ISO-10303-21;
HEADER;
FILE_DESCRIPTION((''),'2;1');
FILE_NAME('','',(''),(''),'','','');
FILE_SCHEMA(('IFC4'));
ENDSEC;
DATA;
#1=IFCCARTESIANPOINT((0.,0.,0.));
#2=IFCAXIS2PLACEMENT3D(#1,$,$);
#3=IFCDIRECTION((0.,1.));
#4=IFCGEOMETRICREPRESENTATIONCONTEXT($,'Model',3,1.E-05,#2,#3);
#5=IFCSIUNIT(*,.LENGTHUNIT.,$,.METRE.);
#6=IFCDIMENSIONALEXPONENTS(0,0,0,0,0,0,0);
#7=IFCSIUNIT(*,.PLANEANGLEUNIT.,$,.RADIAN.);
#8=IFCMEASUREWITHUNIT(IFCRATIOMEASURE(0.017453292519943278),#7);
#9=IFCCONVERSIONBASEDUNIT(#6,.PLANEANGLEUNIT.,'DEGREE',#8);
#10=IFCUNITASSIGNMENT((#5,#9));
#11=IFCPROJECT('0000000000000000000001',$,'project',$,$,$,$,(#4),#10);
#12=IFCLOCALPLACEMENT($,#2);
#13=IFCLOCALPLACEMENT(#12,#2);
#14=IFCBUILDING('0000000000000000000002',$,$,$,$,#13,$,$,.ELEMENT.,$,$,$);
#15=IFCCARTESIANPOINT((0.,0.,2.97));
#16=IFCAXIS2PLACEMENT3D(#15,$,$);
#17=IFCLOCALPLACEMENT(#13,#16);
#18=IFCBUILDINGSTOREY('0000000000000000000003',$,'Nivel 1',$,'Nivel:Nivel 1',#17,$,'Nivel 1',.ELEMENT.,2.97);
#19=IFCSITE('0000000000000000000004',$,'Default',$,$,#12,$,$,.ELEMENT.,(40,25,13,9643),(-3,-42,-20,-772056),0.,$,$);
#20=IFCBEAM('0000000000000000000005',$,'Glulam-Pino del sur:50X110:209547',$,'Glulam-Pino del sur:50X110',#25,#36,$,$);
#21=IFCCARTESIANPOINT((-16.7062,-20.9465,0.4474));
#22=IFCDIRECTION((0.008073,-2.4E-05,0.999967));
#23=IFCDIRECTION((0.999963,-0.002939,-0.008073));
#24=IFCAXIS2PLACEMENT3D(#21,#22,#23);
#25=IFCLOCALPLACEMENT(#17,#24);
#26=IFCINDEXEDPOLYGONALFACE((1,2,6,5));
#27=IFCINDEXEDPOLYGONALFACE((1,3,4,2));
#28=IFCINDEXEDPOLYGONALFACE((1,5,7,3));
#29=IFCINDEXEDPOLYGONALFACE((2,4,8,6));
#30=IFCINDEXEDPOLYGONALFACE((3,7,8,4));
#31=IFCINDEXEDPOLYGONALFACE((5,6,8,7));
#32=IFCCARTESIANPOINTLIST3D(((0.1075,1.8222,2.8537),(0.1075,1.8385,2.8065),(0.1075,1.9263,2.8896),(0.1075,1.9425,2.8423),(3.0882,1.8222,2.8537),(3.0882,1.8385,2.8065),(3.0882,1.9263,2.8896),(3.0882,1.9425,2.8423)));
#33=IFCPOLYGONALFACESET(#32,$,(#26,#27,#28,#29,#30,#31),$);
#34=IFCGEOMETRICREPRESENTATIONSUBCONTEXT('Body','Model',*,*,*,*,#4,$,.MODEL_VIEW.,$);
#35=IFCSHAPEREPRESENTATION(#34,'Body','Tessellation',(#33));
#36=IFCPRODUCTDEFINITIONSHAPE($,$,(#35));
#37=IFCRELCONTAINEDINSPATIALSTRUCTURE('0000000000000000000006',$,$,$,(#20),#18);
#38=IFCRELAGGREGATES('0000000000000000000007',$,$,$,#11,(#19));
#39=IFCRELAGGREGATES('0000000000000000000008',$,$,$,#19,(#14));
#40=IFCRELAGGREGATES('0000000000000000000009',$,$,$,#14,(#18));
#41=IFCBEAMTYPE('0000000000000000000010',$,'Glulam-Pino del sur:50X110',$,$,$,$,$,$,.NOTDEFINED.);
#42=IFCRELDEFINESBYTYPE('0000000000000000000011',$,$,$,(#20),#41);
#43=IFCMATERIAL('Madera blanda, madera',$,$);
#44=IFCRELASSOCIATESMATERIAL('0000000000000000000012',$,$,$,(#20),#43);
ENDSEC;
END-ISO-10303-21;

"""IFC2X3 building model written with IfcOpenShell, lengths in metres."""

from ifc_helpers import new_model, entity, si_unit, converted_unit, direction, frame, frame_2d, origin, place, context, subcontext, project, spatial, rectangle, extrude, material, type_object, element, save


model = new_model("IFC2X3")

# Units and contexts
model_context = context("Model", 3, precision=1e-05, world=origin(), true_north=direction((0.0, 1.0)))
body_context = subcontext(model_context, "Body", "Model", "MODEL_VIEW")
ifc_project = project(units=[si_unit("LENGTHUNIT", "METRE"), converted_unit("PLANEANGLEUNIT", "DEGREE", entity("IfcRatioMeasure", 0.017453292519943278), si_unit("PLANEANGLEUNIT", "RADIAN"), dimensions=[0, 0, 0, 0, 0, 0, 0])], contexts=[model_context])

# Site, building, storey
site_placement = place(None, origin())
site = spatial("IfcSite", under=ifc_project, at=site_placement, Name="Default", CompositionType="ELEMENT", RefLatitude=(40, 25, 13, 9643), RefLongitude=(-3, -42, -20, -772056), RefElevation=0.0)
building_placement = place(site_placement, origin())
building = spatial("IfcBuilding", under=site, at=building_placement, CompositionType="ELEMENT")
storey_placement = place(building_placement, frame((0.0, 0.0, 2.97)))
storey = spatial("IfcBuildingStorey", under=building, at=storey_placement, Name="Nivel 1", ObjectType="Nivel:Nivel 1", LongName="Nivel 1", CompositionType="ELEMENT", Elevation=2.97)

# Beam
ifc_material_1 = material(Name="Madera blanda, madera")
beam_type = type_object("IfcBeamType", Name="Glulam-Pino del sur:50X110", PredefinedType="NOTDEFINED")
beam_placement = place(storey_placement, frame((-16.7062, -20.9465, 0.4474), z_axis=(0.008073, -0.000024, 0.999967), x_axis=(0.999963, -0.002939, -0.008073)))
element("IfcBeam", 1, at=beam_placement, inside=storey, type_object=beam_type, material=ifc_material_1, Name="Glulam-Pino del sur:50X110:209547", ObjectType="Glulam-Pino del sur:50X110", context=body_context, shape_type="SweptSolid", body=[
    extrude(rectangle(XDim=0.05, YDim=0.11, at=frame_2d((0.0, 0.0), x_axis=(0.0, 1.0))), frame((0.1075, 1.8824, 2.848), z_axis=(1.0, 0.0, 0.0), x_axis=(0.0, -0.945519, -0.325568)), (0.0, 0.0, 1.0), 2.9807),
])

save(model, "model.ifc")
